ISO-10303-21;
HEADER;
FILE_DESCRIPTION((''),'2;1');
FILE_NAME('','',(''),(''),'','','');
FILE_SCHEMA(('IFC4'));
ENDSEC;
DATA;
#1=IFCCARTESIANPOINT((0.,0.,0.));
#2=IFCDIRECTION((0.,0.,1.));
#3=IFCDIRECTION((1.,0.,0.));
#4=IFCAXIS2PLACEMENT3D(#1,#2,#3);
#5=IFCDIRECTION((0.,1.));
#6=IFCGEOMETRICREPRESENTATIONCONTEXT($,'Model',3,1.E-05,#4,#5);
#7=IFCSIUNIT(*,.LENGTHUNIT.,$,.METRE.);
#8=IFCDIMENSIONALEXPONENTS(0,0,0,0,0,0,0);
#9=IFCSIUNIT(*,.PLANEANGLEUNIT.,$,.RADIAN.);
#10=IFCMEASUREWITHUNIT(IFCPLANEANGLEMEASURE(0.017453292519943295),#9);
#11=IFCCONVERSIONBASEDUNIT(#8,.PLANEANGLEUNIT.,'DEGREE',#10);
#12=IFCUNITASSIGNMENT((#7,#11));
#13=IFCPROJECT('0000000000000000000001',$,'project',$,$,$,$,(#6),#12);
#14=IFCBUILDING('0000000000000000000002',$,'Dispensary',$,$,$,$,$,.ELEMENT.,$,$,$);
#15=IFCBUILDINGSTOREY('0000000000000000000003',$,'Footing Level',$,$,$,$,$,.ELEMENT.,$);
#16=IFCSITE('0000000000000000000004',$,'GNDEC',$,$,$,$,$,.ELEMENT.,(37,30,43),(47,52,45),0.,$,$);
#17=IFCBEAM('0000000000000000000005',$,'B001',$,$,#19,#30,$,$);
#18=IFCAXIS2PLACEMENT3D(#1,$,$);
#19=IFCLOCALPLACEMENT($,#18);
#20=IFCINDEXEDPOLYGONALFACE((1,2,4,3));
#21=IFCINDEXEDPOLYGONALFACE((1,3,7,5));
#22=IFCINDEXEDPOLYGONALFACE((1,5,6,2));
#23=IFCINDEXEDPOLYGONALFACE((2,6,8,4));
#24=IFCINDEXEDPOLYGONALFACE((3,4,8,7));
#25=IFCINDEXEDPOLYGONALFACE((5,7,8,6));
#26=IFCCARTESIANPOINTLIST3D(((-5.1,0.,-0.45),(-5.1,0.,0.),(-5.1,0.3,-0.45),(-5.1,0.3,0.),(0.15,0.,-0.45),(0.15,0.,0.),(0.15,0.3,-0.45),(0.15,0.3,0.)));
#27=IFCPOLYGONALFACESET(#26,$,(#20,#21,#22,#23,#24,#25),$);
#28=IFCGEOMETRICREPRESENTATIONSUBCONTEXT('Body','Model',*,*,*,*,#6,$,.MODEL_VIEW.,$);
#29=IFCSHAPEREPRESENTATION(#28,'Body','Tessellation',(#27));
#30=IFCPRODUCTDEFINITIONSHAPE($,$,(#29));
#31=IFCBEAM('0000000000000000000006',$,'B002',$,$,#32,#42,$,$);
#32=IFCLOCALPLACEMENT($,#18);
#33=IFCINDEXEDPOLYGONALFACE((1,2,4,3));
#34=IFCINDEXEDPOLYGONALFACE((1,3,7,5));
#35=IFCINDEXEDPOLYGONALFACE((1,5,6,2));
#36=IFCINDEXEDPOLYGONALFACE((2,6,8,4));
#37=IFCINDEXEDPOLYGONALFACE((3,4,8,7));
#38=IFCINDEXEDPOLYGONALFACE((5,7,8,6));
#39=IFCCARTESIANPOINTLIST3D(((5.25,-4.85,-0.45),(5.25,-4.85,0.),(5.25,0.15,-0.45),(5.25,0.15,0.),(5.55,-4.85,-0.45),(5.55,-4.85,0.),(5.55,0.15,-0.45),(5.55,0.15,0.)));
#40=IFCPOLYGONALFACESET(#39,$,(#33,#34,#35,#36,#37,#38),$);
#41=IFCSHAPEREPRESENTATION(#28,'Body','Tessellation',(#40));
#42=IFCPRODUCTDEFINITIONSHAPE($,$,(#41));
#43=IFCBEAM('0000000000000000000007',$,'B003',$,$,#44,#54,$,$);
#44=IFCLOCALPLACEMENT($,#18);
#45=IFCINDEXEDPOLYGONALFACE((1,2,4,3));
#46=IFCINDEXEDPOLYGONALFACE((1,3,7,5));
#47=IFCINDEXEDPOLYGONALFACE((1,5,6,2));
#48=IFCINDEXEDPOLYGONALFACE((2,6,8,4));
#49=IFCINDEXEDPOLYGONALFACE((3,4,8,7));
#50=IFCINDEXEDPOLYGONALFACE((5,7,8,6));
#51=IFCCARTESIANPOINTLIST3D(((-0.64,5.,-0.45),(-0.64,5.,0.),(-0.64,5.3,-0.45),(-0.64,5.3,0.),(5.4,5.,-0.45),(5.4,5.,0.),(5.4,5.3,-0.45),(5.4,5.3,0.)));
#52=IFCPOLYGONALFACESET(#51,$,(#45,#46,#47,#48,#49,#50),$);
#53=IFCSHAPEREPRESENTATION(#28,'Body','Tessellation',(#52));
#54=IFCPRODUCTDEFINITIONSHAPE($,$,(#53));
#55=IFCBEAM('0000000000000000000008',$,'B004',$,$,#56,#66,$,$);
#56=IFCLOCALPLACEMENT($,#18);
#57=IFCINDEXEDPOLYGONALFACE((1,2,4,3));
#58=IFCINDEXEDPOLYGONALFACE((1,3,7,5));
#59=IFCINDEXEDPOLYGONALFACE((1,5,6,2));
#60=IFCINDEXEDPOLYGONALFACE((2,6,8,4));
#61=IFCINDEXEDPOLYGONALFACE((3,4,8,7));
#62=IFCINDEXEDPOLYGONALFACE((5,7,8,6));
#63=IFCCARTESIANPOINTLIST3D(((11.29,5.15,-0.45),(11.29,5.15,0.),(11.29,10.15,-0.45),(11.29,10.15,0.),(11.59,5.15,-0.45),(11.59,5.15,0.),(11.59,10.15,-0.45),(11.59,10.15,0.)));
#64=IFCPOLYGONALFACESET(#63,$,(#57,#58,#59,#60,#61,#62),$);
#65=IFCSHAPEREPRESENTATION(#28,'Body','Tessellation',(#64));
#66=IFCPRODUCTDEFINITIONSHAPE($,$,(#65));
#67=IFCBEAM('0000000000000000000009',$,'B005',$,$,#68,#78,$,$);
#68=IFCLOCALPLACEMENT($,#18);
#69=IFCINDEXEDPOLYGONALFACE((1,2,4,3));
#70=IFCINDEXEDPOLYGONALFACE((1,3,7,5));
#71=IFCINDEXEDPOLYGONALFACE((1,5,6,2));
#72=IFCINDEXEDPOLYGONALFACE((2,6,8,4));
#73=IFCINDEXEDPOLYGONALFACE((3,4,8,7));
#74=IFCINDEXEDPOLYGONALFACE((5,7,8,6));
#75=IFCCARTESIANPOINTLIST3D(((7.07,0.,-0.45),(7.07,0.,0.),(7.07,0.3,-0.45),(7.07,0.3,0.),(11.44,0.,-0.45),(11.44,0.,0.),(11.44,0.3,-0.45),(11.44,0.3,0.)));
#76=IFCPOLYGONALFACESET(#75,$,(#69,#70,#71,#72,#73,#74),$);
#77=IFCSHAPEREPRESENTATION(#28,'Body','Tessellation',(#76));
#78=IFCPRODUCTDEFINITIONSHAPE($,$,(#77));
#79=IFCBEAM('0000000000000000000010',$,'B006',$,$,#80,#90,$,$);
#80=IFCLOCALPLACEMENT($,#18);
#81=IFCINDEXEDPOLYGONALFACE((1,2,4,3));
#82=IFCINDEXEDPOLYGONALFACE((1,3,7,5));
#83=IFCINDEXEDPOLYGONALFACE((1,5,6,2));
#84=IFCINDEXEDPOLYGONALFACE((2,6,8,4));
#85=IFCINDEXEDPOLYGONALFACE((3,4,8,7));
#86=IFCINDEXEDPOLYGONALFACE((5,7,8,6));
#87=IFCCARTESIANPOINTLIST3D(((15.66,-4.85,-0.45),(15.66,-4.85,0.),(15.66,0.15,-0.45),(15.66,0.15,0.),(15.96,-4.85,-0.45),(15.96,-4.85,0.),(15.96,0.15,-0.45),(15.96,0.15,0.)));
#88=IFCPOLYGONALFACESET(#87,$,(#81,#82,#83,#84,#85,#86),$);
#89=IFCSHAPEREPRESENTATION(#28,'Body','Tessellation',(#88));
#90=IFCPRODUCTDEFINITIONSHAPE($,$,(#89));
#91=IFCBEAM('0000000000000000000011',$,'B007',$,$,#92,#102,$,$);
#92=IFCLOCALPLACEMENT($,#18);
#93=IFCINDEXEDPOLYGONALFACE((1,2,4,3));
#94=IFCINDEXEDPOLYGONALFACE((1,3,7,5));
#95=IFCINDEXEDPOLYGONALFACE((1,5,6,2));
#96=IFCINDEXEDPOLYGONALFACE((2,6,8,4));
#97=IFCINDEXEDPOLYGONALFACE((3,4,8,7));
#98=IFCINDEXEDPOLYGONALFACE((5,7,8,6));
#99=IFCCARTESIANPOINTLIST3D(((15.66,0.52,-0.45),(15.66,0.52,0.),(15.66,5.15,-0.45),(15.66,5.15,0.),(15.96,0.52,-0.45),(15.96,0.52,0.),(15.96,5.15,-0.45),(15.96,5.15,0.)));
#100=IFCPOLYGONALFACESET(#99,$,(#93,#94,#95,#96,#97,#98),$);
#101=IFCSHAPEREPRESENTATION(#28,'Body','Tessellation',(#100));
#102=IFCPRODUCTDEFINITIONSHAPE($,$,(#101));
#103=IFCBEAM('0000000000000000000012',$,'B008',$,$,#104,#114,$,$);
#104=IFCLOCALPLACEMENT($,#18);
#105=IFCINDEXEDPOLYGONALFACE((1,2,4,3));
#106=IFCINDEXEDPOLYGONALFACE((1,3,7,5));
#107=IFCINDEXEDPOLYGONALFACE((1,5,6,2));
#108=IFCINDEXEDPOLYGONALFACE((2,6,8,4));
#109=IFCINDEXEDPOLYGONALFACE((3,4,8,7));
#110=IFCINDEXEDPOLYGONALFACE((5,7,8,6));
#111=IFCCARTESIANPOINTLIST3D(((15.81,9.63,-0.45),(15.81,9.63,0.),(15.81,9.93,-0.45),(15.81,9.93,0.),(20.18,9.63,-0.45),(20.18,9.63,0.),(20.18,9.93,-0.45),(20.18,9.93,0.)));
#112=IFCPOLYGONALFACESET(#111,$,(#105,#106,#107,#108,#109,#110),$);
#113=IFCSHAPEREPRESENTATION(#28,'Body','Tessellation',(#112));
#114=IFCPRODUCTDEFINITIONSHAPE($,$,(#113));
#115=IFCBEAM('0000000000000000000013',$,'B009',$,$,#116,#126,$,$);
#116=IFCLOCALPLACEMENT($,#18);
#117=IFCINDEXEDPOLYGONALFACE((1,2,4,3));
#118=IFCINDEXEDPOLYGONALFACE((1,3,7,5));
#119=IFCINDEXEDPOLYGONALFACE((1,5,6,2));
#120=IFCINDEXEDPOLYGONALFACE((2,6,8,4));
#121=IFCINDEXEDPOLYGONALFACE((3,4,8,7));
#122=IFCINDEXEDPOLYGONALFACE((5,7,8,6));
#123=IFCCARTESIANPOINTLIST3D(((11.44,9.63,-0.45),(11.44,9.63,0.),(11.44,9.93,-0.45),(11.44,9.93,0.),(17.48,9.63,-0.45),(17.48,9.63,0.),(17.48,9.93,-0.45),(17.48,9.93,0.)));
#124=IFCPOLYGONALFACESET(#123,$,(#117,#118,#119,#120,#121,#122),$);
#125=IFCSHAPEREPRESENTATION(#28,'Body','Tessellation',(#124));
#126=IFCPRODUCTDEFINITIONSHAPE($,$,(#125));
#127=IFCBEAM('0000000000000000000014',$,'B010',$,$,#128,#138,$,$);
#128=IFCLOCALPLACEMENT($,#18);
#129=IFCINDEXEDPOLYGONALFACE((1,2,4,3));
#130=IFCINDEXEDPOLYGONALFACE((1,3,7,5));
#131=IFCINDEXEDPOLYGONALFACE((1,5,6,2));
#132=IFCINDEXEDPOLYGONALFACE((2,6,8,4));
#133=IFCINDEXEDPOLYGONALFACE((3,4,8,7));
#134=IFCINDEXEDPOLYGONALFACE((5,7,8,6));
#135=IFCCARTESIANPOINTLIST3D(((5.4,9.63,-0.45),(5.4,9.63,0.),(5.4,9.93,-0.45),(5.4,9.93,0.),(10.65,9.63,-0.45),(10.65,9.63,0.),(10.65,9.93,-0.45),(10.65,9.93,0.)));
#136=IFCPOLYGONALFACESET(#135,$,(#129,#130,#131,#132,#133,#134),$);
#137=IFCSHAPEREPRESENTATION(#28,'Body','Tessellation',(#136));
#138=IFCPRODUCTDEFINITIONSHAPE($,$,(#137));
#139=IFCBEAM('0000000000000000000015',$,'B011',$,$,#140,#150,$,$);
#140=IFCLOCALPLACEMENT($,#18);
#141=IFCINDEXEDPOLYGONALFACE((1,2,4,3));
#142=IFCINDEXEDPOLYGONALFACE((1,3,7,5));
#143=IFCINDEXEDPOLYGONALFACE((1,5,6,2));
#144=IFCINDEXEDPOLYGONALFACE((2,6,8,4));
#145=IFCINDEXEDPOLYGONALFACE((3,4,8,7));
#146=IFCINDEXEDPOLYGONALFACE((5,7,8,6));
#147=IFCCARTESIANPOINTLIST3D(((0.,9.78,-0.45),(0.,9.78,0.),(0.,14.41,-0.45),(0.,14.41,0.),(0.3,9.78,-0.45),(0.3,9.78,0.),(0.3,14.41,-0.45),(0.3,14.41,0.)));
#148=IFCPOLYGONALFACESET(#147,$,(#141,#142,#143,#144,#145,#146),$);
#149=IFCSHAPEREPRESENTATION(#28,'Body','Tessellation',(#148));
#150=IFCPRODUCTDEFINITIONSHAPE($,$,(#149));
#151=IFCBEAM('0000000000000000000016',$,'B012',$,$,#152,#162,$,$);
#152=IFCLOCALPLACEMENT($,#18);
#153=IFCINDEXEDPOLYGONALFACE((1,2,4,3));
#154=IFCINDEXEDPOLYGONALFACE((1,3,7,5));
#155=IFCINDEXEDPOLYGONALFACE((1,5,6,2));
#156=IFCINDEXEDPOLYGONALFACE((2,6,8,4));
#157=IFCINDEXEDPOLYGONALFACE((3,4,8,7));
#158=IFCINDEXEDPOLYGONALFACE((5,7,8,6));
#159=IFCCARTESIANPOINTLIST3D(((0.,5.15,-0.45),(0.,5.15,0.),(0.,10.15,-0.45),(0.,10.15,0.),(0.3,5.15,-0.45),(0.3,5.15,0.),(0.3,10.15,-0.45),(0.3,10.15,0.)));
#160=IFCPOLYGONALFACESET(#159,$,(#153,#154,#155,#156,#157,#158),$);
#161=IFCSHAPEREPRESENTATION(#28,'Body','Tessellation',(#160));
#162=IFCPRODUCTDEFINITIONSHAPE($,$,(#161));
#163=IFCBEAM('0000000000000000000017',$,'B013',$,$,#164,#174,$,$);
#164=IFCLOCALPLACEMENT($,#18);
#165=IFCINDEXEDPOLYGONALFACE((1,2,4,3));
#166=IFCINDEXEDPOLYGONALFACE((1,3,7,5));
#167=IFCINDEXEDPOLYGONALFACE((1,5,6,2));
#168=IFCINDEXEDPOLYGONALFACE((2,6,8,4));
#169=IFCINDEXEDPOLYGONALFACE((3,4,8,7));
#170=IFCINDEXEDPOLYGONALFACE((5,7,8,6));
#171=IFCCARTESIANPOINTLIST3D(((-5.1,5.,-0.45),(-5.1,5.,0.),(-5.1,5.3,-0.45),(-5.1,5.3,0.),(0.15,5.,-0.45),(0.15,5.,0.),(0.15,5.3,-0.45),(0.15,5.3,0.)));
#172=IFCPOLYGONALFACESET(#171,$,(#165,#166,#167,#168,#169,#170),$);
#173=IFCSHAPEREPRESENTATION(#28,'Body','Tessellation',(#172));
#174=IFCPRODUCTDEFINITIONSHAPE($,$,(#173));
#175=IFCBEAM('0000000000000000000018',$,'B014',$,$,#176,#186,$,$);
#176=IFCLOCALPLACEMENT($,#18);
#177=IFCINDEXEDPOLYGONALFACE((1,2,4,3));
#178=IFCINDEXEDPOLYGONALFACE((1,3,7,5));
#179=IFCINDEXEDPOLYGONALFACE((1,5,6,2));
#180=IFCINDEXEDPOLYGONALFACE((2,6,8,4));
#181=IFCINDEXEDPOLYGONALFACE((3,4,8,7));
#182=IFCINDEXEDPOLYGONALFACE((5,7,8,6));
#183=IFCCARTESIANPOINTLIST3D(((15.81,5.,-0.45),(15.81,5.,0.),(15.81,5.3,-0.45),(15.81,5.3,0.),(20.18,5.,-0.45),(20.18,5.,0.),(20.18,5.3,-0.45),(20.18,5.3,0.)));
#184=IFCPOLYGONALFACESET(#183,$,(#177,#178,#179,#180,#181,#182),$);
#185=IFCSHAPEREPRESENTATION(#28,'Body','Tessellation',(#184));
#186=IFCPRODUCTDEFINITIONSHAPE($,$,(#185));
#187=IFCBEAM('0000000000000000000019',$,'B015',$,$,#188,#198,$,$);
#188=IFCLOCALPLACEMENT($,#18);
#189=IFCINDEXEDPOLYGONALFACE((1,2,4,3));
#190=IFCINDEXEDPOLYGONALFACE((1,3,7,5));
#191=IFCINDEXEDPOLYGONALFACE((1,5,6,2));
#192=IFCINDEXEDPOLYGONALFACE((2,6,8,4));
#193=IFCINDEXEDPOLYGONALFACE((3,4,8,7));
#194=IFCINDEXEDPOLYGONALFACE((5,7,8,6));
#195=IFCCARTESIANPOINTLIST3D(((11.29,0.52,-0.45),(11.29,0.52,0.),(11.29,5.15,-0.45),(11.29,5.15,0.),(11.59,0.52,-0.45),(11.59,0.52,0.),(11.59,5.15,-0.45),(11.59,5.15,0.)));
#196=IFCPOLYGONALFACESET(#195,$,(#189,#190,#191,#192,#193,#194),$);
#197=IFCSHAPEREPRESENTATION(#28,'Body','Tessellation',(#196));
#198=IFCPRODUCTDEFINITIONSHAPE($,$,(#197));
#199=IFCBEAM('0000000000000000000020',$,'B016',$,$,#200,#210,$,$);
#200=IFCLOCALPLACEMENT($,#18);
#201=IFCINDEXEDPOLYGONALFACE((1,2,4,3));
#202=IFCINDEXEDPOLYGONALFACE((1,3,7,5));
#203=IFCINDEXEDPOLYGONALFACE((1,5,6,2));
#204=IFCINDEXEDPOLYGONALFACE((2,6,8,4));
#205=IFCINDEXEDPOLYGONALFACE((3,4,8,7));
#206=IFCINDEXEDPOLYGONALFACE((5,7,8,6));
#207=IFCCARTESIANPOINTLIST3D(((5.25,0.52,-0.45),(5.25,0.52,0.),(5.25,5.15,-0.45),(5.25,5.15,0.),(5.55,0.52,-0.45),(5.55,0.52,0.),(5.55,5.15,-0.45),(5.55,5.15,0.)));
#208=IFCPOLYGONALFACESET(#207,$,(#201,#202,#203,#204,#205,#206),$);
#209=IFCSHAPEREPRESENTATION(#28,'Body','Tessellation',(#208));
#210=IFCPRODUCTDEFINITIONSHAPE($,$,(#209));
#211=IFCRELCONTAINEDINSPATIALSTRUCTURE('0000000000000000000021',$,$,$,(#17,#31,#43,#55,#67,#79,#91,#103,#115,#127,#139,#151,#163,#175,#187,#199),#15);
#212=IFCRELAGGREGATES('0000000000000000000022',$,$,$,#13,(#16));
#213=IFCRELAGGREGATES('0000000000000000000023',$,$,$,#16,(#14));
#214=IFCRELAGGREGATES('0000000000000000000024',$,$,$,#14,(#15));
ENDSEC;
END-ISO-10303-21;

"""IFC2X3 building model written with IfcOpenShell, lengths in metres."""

from ifc_helpers import new_model, entity, si_unit, converted_unit, direction, frame, frame_2d, origin_with_axes, place, context, subcontext, project, spatial, rectangle, extrude, element, save


model = new_model("IFC2X3")

# Units and contexts
model_context = context("Model", 3, precision=1e-05, world=origin_with_axes(), true_north=direction((0.0, 1.0)))
body_context = subcontext(model_context, "Body", "Model", "MODEL_VIEW")
ifc_project = project(units=[si_unit("LENGTHUNIT", "METRE"), converted_unit("PLANEANGLEUNIT", "DEGREE", entity("IfcPlaneAngleMeasure", 0.017453292519943295), si_unit("PLANEANGLEUNIT", "RADIAN"), dimensions=[0, 0, 0, 0, 0, 0, 0])], contexts=[model_context])

# Site, building, storey
site = spatial("IfcSite", under=ifc_project, Name="GNDEC", CompositionType="ELEMENT", RefLatitude=(37, 30, 43), RefLongitude=(47, 52, 45), RefElevation=0.0)
building = spatial("IfcBuilding", under=site, Name="Dispensary", CompositionType="ELEMENT")
storey = spatial("IfcBuildingStorey", under=building, Name="Footing Level", CompositionType="ELEMENT")

# Beams
placement = place(None, origin_with_axes())
element("IfcBeam", 1, at=placement, inside=storey, Name="B001", context=body_context, shape_type="SweptSolid", body=[
    extrude(rectangle(XDim=0.3, YDim=0.45, at=frame_2d((0.0, 0.0), x_axis=(0.0, 1.0))), frame((0.15, 0.15, -0.225), z_axis=(-1.0, 0.0, 0.0), x_axis=(0.0, 0.0, 1.0)), (0.0, 0.0, 1.0), 5.25),
])
element("IfcBeam", 2, at=placement, inside=storey, Name="B002", context=body_context, shape_type="SweptSolid", body=[
    extrude(rectangle(XDim=0.3, YDim=0.45, at=frame_2d((0.0, 0.0), x_axis=(0.0, 1.0))), frame((5.4, 0.15, -0.225), z_axis=(0.0, -1.0, 0.0), x_axis=(0.0, 0.0, 1.0)), (0.0, 0.0, 1.0), 5.0),
])
element("IfcBeam", 3, at=placement, inside=storey, Name="B003", context=body_context, shape_type="SweptSolid", body=[
    extrude(rectangle(XDim=0.3, YDim=0.45, at=frame_2d((0.0, 0.0), x_axis=(0.0, 1.0))), frame((5.4, 5.15, -0.225), z_axis=(-1.0, 0.0, 0.0), x_axis=(0.0, 0.0, 1.0)), (0.0, 0.0, 1.0), 6.04),
])
element("IfcBeam", 4, at=placement, inside=storey, Name="B004", context=body_context, shape_type="SweptSolid", body=[
    extrude(rectangle(XDim=0.3, YDim=0.45, at=frame_2d((0.0, 0.0), x_axis=(0.0, 1.0))), frame((11.44, 5.15, -0.225), z_axis=(0.0, 1.0, 0.0), x_axis=(0.0, 0.0, 1.0)), (0.0, 0.0, 1.0), 5.0),
])
element("IfcBeam", 5, at=placement, inside=storey, Name="B005", context=body_context, shape_type="SweptSolid", body=[
    extrude(rectangle(XDim=0.3, YDim=0.45, at=frame_2d((0.0, 0.0), x_axis=(0.0, 1.0))), frame((11.44, 0.15, -0.225), z_axis=(-1.0, 0.0, 0.0), x_axis=(0.0, 0.0, 1.0)), (0.0, 0.0, 1.0), 4.37),
])
element("IfcBeam", 6, at=placement, inside=storey, Name="B006", context=body_context, shape_type="SweptSolid", body=[
    extrude(rectangle(XDim=0.3, YDim=0.45, at=frame_2d((0.0, 0.0), x_axis=(0.0, 1.0))), frame((15.81, 0.15, -0.225), z_axis=(0.0, -1.0, 0.0), x_axis=(0.0, 0.0, 1.0)), (0.0, 0.0, 1.0), 5.0),
])
element("IfcBeam", 7, at=placement, inside=storey, Name="B007", context=body_context, shape_type="SweptSolid", body=[
    extrude(rectangle(XDim=0.3, YDim=0.45, at=frame_2d((0.0, 0.0), x_axis=(0.0, 1.0))), frame((15.81, 5.15, -0.225), z_axis=(0.0, -1.0, 0.0), x_axis=(0.0, 0.0, 1.0)), (0.0, 0.0, 1.0), 4.63),
])
element("IfcBeam", 8, at=placement, inside=storey, Name="B008", context=body_context, shape_type="SweptSolid", body=[
    extrude(rectangle(XDim=0.3, YDim=0.45, at=frame_2d((0.0, 0.0), x_axis=(0.0, 1.0))), frame((15.81, 9.78, -0.225), z_axis=(1.0, 0.0, 0.0), x_axis=(0.0, 0.0, 1.0)), (0.0, 0.0, 1.0), 4.37),
])
element("IfcBeam", 9, at=placement, inside=storey, Name="B009", context=body_context, shape_type="SweptSolid", body=[
    extrude(rectangle(XDim=0.3, YDim=0.45, at=frame_2d((0.0, 0.0), x_axis=(0.0, 1.0))), frame((11.44, 9.78, -0.225), z_axis=(1.0, 0.0, 0.0), x_axis=(0.0, 0.0, 1.0)), (0.0, 0.0, 1.0), 6.04),
])
element("IfcBeam", 10, at=placement, inside=storey, Name="B010", context=body_context, shape_type="SweptSolid", body=[
    extrude(rectangle(XDim=0.3, YDim=0.45, at=frame_2d((0.0, 0.0), x_axis=(0.0, 1.0))), frame((5.4, 9.78, -0.225), z_axis=(1.0, 0.0, 0.0), x_axis=(0.0, 0.0, 1.0)), (0.0, 0.0, 1.0), 5.25),
])
element("IfcBeam", 11, at=placement, inside=storey, Name="B011", context=body_context, shape_type="SweptSolid", body=[
    extrude(rectangle(XDim=0.3, YDim=0.45, at=frame_2d((0.0, 0.0), x_axis=(0.0, 1.0))), frame((0.15, 9.78, -0.225), z_axis=(0.0, 1.0, 0.0), x_axis=(0.0, 0.0, 1.0)), (0.0, 0.0, 1.0), 4.63),
])
element("IfcBeam", 12, at=placement, inside=storey, Name="B012", context=body_context, shape_type="SweptSolid", body=[
    extrude(rectangle(XDim=0.3, YDim=0.45, at=frame_2d((0.0, 0.0), x_axis=(0.0, 1.0))), frame((0.15, 5.15, -0.225), z_axis=(0.0, 1.0, 0.0), x_axis=(0.0, 0.0, 1.0)), (0.0, 0.0, 1.0), 5.0),
])
element("IfcBeam", 13, at=placement, inside=storey, Name="B013", context=body_context, shape_type="SweptSolid", body=[
    extrude(rectangle(XDim=0.3, YDim=0.45, at=frame_2d((0.0, 0.0), x_axis=(0.0, 1.0))), frame((0.15, 5.15, -0.225), z_axis=(-1.0, 0.0, 0.0), x_axis=(0.0, 0.0, 1.0)), (0.0, 0.0, 1.0), 5.25),
])
element("IfcBeam", 14, at=placement, inside=storey, Name="B014", context=body_context, shape_type="SweptSolid", body=[
    extrude(rectangle(XDim=0.3, YDim=0.45, at=frame_2d((0.0, 0.0), x_axis=(0.0, 1.0))), frame((15.81, 5.15, -0.225), z_axis=(1.0, 0.0, 0.0), x_axis=(0.0, 0.0, 1.0)), (0.0, 0.0, 1.0), 4.37),
])
element("IfcBeam", 15, at=placement, inside=storey, Name="B015", context=body_context, shape_type="SweptSolid", body=[
    extrude(rectangle(XDim=0.3, YDim=0.45, at=frame_2d((0.0, 0.0), x_axis=(0.0, 1.0))), frame((11.44, 5.15, -0.225), z_axis=(0.0, -1.0, 0.0), x_axis=(0.0, 0.0, 1.0)), (0.0, 0.0, 1.0), 4.63),
])
element("IfcBeam", 16, at=placement, inside=storey, Name="B016", context=body_context, shape_type="SweptSolid", body=[
    extrude(rectangle(XDim=0.3, YDim=0.45, at=frame_2d((0.0, 0.0), x_axis=(0.0, 1.0))), frame((5.4, 5.15, -0.225), z_axis=(0.0, -1.0, 0.0), x_axis=(0.0, 0.0, 1.0)), (0.0, 0.0, 1.0), 4.63),
])

save(model, "model.ifc")
